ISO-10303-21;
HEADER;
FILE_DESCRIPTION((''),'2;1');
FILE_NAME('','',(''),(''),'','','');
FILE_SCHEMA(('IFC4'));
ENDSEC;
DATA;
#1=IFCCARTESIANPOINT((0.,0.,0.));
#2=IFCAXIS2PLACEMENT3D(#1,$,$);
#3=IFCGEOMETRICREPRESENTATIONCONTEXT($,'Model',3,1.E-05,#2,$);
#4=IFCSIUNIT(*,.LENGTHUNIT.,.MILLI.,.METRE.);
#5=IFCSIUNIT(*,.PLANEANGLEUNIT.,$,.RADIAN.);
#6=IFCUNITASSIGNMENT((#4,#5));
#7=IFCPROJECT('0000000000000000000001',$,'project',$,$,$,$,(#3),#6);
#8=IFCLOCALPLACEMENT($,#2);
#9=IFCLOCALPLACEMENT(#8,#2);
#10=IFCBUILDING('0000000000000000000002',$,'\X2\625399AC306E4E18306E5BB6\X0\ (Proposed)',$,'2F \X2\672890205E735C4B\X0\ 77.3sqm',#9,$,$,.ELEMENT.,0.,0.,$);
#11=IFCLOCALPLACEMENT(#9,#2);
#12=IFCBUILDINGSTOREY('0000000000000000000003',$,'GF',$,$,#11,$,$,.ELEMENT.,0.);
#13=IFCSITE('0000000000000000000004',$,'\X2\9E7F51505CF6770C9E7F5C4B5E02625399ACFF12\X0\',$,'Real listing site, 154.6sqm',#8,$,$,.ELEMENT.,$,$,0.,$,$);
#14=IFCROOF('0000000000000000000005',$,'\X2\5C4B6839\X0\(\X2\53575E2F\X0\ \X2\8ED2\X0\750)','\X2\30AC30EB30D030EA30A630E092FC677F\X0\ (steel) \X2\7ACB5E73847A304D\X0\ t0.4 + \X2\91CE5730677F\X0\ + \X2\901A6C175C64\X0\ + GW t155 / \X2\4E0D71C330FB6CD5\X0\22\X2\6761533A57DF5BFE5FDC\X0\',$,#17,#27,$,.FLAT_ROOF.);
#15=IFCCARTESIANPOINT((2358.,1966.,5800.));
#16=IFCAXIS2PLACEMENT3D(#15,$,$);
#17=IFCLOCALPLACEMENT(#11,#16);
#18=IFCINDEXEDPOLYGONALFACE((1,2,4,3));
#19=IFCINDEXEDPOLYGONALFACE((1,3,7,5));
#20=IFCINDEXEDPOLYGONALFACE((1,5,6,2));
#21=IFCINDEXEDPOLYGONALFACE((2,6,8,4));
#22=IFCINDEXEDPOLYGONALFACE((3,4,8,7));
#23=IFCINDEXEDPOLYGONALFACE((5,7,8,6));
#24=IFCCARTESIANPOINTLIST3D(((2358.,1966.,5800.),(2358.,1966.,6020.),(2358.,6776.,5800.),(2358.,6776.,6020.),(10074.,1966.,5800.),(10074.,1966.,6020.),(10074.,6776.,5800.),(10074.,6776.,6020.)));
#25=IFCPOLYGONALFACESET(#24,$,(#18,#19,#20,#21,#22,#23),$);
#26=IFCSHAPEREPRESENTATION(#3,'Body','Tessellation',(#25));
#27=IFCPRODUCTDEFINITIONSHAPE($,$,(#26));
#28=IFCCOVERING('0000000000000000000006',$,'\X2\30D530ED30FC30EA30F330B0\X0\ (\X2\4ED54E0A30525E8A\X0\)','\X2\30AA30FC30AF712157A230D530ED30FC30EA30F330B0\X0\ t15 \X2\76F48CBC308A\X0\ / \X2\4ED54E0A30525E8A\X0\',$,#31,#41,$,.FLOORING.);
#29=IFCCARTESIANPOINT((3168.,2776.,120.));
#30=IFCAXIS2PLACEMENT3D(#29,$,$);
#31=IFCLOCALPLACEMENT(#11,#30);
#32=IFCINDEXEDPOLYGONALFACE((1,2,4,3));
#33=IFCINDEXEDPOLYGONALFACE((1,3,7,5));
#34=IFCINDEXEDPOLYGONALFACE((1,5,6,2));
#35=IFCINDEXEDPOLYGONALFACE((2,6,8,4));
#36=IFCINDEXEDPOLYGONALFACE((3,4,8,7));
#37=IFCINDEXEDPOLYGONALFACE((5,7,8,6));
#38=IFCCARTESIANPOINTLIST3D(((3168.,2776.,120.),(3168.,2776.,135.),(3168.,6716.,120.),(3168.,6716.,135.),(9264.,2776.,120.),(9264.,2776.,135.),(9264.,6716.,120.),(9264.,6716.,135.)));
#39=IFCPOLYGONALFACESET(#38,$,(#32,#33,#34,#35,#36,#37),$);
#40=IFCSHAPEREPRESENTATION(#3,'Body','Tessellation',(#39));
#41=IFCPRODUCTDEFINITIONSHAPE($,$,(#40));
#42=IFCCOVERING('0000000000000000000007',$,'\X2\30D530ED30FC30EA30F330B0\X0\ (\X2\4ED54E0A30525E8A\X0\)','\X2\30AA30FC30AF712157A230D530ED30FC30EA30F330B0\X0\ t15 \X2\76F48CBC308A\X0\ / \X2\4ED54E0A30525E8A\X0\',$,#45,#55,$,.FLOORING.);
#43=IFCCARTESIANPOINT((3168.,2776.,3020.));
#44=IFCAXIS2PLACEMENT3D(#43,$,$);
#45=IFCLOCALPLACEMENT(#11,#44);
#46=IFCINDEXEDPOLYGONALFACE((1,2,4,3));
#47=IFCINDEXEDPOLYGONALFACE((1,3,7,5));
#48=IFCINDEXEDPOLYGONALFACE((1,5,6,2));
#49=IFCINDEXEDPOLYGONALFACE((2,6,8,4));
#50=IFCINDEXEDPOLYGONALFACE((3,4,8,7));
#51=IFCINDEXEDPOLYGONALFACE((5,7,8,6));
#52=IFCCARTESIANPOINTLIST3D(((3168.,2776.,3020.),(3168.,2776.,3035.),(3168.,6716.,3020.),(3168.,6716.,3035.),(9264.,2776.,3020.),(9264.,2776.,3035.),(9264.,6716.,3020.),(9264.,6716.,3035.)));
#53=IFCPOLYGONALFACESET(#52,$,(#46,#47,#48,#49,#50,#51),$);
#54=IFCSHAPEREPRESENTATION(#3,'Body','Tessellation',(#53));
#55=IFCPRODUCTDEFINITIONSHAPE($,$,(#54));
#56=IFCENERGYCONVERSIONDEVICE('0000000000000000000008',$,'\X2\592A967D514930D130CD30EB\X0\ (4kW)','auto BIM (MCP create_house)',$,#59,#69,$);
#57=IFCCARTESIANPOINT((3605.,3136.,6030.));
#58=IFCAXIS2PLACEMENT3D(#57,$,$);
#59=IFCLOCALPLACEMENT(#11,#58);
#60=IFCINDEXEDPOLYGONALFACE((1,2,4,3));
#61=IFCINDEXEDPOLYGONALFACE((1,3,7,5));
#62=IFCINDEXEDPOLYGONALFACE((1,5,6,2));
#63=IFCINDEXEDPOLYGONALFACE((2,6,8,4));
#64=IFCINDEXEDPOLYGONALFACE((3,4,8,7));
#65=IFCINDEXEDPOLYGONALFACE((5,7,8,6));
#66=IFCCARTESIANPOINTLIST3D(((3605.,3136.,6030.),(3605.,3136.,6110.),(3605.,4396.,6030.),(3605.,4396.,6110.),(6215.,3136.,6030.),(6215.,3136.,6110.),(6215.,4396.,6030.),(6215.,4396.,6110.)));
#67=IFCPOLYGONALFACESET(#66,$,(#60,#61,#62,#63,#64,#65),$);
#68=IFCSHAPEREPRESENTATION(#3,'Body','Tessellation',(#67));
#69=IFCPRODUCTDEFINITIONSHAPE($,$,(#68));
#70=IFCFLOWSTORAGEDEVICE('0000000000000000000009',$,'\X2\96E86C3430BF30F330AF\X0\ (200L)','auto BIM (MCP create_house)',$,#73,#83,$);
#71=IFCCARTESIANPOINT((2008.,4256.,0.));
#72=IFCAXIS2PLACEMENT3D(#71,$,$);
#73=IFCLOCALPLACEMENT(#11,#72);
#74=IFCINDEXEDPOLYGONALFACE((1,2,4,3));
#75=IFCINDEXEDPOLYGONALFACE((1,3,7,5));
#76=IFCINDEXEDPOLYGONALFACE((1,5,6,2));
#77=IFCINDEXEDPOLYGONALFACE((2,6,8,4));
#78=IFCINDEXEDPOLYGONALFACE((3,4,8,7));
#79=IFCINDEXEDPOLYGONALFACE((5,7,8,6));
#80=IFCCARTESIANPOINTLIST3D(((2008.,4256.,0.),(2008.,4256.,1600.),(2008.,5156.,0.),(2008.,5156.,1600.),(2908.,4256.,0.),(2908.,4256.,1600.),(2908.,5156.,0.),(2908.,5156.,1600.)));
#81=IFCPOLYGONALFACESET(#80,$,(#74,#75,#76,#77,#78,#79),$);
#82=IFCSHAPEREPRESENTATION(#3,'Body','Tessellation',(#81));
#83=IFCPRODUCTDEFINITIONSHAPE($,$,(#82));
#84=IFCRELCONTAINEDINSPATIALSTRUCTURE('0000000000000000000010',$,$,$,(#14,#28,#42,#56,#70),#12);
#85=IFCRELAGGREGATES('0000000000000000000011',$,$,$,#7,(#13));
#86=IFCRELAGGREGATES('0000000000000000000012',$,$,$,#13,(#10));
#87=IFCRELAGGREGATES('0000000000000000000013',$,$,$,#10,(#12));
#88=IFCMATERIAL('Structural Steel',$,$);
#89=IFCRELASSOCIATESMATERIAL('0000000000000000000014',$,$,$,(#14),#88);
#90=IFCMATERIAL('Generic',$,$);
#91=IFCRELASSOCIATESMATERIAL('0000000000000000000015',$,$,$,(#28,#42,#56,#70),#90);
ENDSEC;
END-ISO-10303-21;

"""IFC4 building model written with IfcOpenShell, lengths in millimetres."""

from ifc_helpers import new_model, si_unit, frame, frame_2d, origin, place, context, project, spatial, rectangle, extrude, material, element, save


model = new_model("IFC4")

# Units and contexts
model_context = context("Model", 3, precision=1e-05, world=origin())
ifc_project = project(units=[si_unit("LENGTHUNIT", "METRE", prefix="MILLI"), si_unit("PLANEANGLEUNIT", "RADIAN")], contexts=[model_context])

# Site, building, storey
site_placement = place(None, origin())
site = spatial("IfcSite", under=ifc_project, at=site_placement, Name="鹿児島県鹿屋市打馬２", ObjectType="Real listing site, 154.6sqm", CompositionType="ELEMENT", RefElevation=0.0)
building_placement = place(site_placement, origin())
building = spatial("IfcBuilding", under=site, at=building_placement, Name="打馬の丘の家 (Proposed)", ObjectType="2F 木造平屋 77.3sqm", CompositionType="ELEMENT", ElevationOfRefHeight=0.0, ElevationOfTerrain=0.0)
storey_placement = place(building_placement, origin())
storey = spatial("IfcBuildingStorey", under=building, at=storey_placement, Name="GF", CompositionType="ELEMENT", Elevation=0.0)

# Roof
ifc_material_1 = material(Name="Structural Steel")
for number, where, name in (
    (1, (2358.0, 1966.0, 5800.0), "屋根(南帯 軒750)"),
):
    element("IfcRoof", number, at=place(storey_placement, frame(where)), inside=storey, material=ifc_material_1, Name=name, Description="ガルバリウム鋼板 (steel) 立平葺き t0.4 + 野地板 + 通気層 + GW t155 / 不燃・法22条区域対応", PredefinedType="FLAT_ROOF", context=model_context, shape_type="SweptSolid", body=[
        extrude(rectangle(XDim=7716.0, YDim=4810.0, at=frame_2d((3858.0, 2405.0))), frame((2358.0, 1966.0, 5800.0)), (0.0, 0.0, 1.0), 220.0),
    ])

# Coverings
ifc_material_2 = material(Name="Generic")
covering_1_placement = place(storey_placement, frame((3168.0, 2776.0, 120.0)))
element("IfcCovering", 2, at=covering_1_placement, inside=storey, material=ifc_material_2, Name="フローリング (仕上げ床)", Description="オーク無垢フローリング t15 直貼り / 仕上げ床", PredefinedType="FLOORING", context=model_context, shape_type="SweptSolid", body=[
    extrude(rectangle(XDim=6096.0, YDim=3940.0, at=frame_2d((3048.0, 1970.0))), frame((3168.0, 2776.0, 120.0)), (0.0, 0.0, 1.0), 15.0),
])
covering_2_placement = place(storey_placement, frame((3168.0, 2776.0, 3020.0)))
element("IfcCovering", 3, at=covering_2_placement, inside=storey, material=ifc_material_2, Name="フローリング (仕上げ床)", Description="オーク無垢フローリング t15 直貼り / 仕上げ床", PredefinedType="FLOORING", context=model_context, shape_type="SweptSolid", body=[
    extrude(rectangle(XDim=6096.0, YDim=3940.0, at=frame_2d((3048.0, 1970.0))), frame((3168.0, 2776.0, 3020.0)), (0.0, 0.0, 1.0), 15.0),
])

# Energy conversion device
energy_conversion_device_placement = place(storey_placement, frame((3605.0, 3136.0, 6030.0)))
element("IfcEnergyConversionDevice", 4, at=energy_conversion_device_placement, inside=storey, material=ifc_material_2, Name="太陽光パネル (4kW)", Description="auto BIM (MCP create_house)", context=model_context, shape_type="SweptSolid", body=[
    extrude(rectangle(XDim=2610.0, YDim=1260.0, at=frame_2d((1305.0, 630.0))), frame((3605.0, 3136.0, 6030.0)), (0.0, 0.0, 1.0), 80.0),
])

# Flow storage device
flow_storage_device_placement = place(storey_placement, frame((2008.0, 4256.0, 0.0)))
element("IfcFlowStorageDevice", 5, at=flow_storage_device_placement, inside=storey, material=ifc_material_2, Name="雨水タンク (200L)", Description="auto BIM (MCP create_house)", context=model_context, shape_type="SweptSolid", body=[
    extrude(rectangle(XDim=900.0, YDim=900.0, at=frame_2d((450.0, 450.0))), frame((2008.0, 4256.0, 0.0)), (0.0, 0.0, 1.0), 1600.0),
])

save(model, "model.ifc")
